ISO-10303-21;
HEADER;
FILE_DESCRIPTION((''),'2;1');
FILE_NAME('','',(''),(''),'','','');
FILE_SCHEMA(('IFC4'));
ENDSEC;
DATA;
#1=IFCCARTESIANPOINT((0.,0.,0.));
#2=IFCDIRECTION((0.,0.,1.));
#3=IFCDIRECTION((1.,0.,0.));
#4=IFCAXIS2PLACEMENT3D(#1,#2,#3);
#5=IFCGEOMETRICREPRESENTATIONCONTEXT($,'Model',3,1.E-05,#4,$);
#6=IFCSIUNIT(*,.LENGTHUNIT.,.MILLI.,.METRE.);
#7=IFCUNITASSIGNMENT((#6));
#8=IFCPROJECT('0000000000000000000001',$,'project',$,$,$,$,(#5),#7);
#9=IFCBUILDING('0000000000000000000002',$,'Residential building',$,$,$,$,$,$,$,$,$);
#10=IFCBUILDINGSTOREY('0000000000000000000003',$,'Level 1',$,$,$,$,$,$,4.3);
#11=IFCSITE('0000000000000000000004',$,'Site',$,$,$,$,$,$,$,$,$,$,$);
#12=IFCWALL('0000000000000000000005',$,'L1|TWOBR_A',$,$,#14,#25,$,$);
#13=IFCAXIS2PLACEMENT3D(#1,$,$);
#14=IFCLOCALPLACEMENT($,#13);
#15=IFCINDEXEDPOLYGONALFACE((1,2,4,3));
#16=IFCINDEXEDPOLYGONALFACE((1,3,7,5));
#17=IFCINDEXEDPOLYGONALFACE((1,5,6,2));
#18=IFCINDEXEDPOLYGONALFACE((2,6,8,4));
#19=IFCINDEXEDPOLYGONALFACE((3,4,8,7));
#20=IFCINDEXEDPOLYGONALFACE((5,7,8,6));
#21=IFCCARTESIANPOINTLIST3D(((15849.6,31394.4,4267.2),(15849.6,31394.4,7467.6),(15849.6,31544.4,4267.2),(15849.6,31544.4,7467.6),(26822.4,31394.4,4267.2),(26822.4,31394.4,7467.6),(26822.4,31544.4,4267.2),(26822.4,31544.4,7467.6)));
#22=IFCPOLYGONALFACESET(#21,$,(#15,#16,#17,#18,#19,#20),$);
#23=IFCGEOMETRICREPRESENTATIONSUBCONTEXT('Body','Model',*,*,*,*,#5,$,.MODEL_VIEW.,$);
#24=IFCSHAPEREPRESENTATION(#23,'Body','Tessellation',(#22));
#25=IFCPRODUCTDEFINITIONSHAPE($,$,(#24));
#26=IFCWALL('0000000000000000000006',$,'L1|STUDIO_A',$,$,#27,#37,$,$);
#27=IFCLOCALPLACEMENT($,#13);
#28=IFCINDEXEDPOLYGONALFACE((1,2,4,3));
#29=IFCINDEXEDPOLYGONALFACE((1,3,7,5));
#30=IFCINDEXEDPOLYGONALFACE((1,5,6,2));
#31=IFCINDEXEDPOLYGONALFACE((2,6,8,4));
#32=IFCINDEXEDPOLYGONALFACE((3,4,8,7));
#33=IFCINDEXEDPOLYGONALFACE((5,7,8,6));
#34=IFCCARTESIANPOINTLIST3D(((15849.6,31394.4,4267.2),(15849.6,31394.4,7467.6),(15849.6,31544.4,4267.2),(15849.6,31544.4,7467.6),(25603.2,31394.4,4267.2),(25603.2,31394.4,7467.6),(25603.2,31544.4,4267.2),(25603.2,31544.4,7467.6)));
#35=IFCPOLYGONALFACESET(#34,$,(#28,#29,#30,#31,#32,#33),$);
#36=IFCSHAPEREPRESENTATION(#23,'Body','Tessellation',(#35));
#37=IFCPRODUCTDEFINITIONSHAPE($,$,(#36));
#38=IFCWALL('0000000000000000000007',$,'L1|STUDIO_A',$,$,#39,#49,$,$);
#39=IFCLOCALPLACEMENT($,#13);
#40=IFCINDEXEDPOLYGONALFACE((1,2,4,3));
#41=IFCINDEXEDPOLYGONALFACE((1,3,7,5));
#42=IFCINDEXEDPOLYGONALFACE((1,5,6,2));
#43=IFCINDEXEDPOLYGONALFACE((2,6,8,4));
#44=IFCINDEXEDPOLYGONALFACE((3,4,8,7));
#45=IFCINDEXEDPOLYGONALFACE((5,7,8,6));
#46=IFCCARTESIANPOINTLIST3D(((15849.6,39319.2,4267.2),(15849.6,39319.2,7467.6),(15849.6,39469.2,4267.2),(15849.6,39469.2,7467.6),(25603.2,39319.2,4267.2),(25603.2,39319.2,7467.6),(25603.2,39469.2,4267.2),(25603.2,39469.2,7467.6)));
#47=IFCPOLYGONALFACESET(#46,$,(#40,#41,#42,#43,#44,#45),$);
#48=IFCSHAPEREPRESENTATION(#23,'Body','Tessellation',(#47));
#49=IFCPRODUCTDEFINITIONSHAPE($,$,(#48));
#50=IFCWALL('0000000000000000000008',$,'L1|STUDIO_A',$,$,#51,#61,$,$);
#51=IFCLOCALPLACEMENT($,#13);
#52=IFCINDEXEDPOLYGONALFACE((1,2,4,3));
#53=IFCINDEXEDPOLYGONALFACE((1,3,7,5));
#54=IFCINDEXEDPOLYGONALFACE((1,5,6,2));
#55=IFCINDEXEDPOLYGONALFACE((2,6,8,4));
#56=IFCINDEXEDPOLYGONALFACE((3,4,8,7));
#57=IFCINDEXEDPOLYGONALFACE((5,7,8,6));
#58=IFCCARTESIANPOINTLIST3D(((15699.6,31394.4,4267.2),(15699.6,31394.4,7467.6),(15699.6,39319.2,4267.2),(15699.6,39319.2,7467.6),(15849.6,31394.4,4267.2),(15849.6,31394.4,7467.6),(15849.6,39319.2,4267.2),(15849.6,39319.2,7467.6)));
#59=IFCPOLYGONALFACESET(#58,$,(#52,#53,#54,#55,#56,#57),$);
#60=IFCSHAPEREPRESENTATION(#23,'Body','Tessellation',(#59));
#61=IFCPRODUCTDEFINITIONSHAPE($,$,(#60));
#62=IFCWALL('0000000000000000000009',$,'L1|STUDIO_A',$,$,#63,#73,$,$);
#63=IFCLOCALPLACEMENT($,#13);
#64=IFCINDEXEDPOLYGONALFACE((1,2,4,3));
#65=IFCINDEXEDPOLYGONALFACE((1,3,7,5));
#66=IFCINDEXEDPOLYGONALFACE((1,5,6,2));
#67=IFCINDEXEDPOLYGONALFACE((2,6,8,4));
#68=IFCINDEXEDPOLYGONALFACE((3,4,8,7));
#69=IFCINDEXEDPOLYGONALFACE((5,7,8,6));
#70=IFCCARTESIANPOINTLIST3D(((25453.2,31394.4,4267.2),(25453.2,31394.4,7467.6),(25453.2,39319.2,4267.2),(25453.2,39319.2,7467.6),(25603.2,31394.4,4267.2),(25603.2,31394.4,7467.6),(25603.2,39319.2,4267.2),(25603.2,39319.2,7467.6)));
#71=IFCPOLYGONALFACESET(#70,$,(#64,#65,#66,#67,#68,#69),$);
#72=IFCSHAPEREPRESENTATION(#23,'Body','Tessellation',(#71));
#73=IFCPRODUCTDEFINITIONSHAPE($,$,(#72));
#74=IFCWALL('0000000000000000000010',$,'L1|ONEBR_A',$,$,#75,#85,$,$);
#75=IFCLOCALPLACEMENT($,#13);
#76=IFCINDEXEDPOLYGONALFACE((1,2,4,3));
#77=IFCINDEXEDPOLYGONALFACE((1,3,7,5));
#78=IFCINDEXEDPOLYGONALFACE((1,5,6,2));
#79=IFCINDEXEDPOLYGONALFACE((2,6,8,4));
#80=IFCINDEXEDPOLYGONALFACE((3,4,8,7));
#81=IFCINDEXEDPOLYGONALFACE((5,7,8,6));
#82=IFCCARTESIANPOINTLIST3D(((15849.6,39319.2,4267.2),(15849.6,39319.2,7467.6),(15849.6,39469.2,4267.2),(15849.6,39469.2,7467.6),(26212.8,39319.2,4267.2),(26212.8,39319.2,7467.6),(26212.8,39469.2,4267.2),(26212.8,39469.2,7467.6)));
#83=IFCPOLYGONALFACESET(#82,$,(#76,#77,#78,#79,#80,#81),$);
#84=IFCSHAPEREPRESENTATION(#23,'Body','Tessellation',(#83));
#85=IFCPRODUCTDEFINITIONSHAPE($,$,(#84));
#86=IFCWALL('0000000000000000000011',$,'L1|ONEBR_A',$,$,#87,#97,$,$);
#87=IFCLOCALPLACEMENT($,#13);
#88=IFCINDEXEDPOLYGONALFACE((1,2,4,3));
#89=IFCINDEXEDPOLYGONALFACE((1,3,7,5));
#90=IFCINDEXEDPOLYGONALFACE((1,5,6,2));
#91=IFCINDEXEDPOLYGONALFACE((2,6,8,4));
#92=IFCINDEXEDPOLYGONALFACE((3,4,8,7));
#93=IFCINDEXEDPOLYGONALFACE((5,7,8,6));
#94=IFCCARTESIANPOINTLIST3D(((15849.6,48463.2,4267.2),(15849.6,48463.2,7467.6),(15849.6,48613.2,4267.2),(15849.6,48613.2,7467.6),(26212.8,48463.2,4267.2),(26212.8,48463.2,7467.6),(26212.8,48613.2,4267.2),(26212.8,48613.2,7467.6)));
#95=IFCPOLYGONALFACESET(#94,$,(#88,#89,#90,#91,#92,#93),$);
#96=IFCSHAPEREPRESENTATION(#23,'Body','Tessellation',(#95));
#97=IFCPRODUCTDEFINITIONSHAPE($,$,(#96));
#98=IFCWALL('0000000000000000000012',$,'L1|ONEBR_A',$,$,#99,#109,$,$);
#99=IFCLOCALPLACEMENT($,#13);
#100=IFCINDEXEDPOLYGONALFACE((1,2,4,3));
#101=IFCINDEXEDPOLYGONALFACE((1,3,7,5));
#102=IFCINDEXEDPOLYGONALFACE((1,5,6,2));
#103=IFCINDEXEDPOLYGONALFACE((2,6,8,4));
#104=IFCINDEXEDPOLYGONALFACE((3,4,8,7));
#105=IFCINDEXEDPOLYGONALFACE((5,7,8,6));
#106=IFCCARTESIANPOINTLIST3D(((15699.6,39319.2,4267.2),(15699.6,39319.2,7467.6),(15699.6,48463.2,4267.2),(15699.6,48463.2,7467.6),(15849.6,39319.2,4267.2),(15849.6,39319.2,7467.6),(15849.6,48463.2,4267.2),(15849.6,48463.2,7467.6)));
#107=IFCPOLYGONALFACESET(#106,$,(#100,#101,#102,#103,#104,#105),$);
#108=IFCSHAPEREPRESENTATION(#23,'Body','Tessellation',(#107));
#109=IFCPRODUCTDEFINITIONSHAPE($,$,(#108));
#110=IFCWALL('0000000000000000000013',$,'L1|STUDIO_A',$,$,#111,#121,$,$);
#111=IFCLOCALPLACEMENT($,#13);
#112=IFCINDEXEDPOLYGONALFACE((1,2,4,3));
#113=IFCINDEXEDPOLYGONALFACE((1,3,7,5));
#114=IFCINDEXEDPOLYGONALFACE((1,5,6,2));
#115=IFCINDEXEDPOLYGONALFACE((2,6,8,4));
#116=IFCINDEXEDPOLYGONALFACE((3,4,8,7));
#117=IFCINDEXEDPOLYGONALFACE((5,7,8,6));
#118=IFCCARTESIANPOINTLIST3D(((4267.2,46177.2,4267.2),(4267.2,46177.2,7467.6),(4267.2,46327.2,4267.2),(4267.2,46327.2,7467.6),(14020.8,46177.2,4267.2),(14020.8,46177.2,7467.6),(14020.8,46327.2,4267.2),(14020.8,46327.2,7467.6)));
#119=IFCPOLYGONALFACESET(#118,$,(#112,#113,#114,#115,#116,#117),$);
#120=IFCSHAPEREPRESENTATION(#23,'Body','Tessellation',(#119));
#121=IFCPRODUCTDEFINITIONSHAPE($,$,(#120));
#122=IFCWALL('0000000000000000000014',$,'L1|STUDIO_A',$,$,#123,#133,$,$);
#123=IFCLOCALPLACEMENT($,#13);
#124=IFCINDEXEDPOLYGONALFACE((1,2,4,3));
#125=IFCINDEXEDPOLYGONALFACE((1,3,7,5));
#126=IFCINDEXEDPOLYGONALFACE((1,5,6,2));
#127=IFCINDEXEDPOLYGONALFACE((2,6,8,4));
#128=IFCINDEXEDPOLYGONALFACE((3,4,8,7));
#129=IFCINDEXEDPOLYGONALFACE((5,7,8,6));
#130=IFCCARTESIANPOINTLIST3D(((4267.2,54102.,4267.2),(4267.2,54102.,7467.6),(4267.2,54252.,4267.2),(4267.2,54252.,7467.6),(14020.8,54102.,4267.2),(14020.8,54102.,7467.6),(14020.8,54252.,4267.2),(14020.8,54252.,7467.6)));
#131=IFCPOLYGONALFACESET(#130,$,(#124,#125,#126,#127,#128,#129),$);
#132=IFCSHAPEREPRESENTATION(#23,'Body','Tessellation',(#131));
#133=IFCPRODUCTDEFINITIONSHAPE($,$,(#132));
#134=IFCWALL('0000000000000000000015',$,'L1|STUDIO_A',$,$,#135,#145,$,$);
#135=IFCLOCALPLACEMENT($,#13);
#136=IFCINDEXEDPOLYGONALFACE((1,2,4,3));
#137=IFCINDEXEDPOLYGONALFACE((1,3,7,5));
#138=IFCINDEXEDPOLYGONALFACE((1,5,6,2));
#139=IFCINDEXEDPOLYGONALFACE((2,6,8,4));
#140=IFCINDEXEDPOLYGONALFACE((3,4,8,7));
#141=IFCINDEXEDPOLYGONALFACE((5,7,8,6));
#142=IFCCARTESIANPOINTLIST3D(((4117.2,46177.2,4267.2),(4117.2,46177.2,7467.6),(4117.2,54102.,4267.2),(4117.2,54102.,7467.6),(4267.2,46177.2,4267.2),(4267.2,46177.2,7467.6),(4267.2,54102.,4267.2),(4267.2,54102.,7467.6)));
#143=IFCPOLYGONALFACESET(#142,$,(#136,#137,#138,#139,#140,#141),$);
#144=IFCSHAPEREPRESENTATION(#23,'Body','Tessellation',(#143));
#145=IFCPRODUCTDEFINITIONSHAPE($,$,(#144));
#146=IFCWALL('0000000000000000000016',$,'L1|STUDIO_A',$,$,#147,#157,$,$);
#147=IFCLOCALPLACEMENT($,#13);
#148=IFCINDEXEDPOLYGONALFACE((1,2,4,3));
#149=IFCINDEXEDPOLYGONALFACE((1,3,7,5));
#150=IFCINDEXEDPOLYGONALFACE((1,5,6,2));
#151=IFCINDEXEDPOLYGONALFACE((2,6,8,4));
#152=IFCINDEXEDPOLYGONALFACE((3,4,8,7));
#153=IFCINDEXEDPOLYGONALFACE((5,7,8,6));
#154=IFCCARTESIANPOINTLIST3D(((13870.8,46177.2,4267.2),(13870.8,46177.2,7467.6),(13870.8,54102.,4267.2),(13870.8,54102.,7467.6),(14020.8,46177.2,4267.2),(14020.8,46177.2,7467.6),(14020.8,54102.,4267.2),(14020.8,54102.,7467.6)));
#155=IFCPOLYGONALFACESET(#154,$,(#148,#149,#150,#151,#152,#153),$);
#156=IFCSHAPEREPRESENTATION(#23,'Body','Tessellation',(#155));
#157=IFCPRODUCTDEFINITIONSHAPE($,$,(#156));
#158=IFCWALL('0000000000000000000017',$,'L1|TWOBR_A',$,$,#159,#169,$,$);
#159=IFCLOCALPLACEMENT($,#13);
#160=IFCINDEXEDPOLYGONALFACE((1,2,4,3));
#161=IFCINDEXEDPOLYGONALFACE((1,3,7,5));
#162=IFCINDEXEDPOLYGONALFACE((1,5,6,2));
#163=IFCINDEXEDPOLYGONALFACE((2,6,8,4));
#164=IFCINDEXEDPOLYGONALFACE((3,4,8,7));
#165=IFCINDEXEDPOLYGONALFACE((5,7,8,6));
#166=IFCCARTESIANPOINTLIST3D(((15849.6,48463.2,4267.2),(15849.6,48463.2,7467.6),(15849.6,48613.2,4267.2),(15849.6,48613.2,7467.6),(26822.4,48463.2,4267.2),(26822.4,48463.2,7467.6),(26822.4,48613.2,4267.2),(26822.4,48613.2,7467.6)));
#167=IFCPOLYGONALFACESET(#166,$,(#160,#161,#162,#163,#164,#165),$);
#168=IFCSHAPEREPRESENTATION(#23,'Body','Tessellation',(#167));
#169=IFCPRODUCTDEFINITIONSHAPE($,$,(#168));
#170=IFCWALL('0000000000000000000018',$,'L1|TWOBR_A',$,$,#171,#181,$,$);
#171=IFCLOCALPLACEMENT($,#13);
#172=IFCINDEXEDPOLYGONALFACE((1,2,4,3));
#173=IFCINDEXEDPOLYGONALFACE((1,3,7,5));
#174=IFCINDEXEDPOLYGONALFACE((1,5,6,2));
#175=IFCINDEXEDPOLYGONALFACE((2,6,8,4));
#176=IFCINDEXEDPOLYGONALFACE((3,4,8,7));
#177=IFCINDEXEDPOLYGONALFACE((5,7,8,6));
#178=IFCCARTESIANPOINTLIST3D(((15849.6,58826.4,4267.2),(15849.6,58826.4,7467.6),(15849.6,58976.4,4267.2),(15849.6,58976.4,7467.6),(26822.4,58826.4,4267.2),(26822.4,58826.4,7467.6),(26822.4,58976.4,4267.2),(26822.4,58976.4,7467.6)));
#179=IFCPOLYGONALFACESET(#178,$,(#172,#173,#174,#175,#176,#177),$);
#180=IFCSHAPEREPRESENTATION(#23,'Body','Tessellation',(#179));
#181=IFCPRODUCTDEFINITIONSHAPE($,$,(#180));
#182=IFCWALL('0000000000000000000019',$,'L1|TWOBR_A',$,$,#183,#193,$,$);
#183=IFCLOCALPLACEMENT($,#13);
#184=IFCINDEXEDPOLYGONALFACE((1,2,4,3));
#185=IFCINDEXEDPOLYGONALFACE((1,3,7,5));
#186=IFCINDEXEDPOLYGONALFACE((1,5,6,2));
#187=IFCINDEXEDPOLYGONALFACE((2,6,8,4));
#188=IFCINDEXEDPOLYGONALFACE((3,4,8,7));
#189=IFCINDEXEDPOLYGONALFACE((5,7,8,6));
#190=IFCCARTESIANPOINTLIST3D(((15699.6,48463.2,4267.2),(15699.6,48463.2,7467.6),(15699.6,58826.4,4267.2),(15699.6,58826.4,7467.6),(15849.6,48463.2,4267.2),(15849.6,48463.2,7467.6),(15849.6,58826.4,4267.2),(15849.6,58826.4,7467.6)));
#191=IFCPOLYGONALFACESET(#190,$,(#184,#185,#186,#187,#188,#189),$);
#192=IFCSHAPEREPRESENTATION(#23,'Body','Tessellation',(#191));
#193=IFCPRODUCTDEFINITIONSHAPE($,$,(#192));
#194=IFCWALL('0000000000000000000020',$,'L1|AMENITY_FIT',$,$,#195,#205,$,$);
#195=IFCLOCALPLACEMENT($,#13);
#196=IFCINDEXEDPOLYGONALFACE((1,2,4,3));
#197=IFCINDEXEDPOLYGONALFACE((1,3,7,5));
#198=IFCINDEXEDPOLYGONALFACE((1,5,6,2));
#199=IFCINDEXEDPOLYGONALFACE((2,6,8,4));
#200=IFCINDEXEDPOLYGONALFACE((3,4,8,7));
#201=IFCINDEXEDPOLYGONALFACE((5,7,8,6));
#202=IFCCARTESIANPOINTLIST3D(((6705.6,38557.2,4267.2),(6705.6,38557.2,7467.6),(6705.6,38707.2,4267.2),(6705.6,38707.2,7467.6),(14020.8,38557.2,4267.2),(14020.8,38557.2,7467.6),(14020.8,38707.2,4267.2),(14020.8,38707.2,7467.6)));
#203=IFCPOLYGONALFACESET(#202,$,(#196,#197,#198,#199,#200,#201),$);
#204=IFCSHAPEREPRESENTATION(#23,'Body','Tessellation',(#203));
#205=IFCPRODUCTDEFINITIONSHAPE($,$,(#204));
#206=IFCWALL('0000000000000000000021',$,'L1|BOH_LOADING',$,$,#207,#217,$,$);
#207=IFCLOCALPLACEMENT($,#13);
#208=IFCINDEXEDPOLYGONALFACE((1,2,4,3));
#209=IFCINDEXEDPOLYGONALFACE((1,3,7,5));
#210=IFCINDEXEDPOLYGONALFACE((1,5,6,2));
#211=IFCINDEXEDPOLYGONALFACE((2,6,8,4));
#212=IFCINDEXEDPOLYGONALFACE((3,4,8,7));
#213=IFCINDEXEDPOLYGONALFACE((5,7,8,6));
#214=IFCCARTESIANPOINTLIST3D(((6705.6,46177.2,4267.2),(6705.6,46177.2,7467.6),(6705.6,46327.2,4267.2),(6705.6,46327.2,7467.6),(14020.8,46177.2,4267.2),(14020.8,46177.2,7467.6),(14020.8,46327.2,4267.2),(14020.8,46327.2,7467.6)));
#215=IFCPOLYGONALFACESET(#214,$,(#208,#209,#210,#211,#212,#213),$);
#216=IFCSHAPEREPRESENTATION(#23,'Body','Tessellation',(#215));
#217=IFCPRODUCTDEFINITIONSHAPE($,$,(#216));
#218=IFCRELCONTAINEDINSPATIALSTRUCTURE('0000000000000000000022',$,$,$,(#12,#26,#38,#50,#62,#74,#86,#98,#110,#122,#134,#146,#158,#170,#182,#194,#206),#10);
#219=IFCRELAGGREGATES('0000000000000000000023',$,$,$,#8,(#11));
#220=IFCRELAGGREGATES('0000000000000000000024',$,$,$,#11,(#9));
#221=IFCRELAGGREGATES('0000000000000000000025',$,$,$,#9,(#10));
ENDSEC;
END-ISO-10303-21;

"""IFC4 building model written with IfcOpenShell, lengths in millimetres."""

from ifc_helpers import new_model, si_unit, frame, origin_with_axes, place, context, subcontext, project, spatial, indexed_curve, outline, extrude, element, save


model = new_model("IFC4")

# Units and contexts
model_context = context("Model", 3, precision=1e-05, world=origin_with_axes())
body_context = subcontext(model_context, "Body", "Model", "MODEL_VIEW")
ifc_project = project(units=[si_unit("LENGTHUNIT", "METRE", prefix="MILLI")], contexts=[model_context])

# Site, building, storey
site = spatial("IfcSite", under=ifc_project, Name="Site")
building = spatial("IfcBuilding", under=site, Name="Residential building")
storey = spatial("IfcBuildingStorey", under=building, Name="Level 1", Elevation=4.3)

# Walls
wall_1_placement = place(None, frame((15849.6, 31394.4, 4267.2), z_axis=(0.0, 0.0, 1.0), x_axis=(1.0, 0.0, 0.0)))
element("IfcWall", 1, at=wall_1_placement, inside=storey, Name="L1|TWOBR_A", context=body_context, shape_type="SweptSolid", body=[
    extrude(outline(indexed_curve([(0.0, 0.0), (0.0, 150.0), (10972.8, 150.0), (10972.8, 0.0), (0.0, 0.0)], self_intersect=False)), origin_with_axes(), (0.0, 0.0, 1.0), 3200.4),
])
for number, where, z_axis, x_axis, name in (
    (2, (15849.6, 31394.4, 4267.2), (0.0, 0.0, 1.0), (1.0, 0.0, 0.0), "L1|STUDIO_A"),
    (3, (15849.6, 39319.2, 4267.2), (0.0, 0.0, 1.0), (1.0, 0.0, 0.0), "L1|STUDIO_A"),
):
    element("IfcWall", number, at=place(None, frame(where, z_axis=z_axis, x_axis=x_axis)), inside=storey, Name=name, context=body_context, shape_type="SweptSolid", body=[
        extrude(outline(indexed_curve([(0.0, 0.0), (0.0, 150.0), (9753.6, 150.0), (9753.6, 0.0), (0.0, 0.0)], self_intersect=False)), origin_with_axes(), (0.0, 0.0, 1.0), 3200.4),
    ])
for number, where, z_axis, x_axis, name in (
    (4, (15849.6, 31394.4, 4267.2), (0.0, 0.0, 1.0), (0.0, 1.0, 0.0), "L1|STUDIO_A"),
    (5, (25603.2, 31394.4, 4267.2), (0.0, 0.0, 1.0), (0.0, 1.0, 0.0), "L1|STUDIO_A"),
):
    element("IfcWall", number, at=place(None, frame(where, z_axis=z_axis, x_axis=x_axis)), inside=storey, Name=name, context=body_context, shape_type="SweptSolid", body=[
        extrude(outline(indexed_curve([(0.0, 0.0), (0.0, 150.0), (7924.8, 150.0), (7924.8, 0.0), (0.0, 0.0)], self_intersect=False)), origin_with_axes(), (0.0, 0.0, 1.0), 3200.4),
    ])
for number, where, z_axis, x_axis, name in (
    (6, (15849.6, 39319.2, 4267.2), (0.0, 0.0, 1.0), (1.0, 0.0, 0.0), "L1|ONEBR_A"),
    (7, (15849.6, 48463.2, 4267.2), (0.0, 0.0, 1.0), (1.0, 0.0, 0.0), "L1|ONEBR_A"),
):
    element("IfcWall", number, at=place(None, frame(where, z_axis=z_axis, x_axis=x_axis)), inside=storey, Name=name, context=body_context, shape_type="SweptSolid", body=[
        extrude(outline(indexed_curve([(0.0, 0.0), (0.0, 150.0), (10363.2, 150.0), (10363.2, 0.0), (0.0, 0.0)], self_intersect=False)), origin_with_axes(), (0.0, 0.0, 1.0), 3200.4),
    ])
wall_2_placement = place(None, frame((15849.6, 39319.2, 4267.2), z_axis=(0.0, 0.0, 1.0), x_axis=(0.0, 1.0, 0.0)))
element("IfcWall", 8, at=wall_2_placement, inside=storey, Name="L1|ONEBR_A", context=body_context, shape_type="SweptSolid", body=[
    extrude(outline(indexed_curve([(0.0, 0.0), (0.0, 150.0), (9144.0, 150.0), (9144.0, 0.0), (0.0, 0.0)], self_intersect=False)), origin_with_axes(), (0.0, 0.0, 1.0), 3200.4),
])
for number, where, z_axis, x_axis, name in (
    (9, (4267.2, 46177.2, 4267.2), (0.0, 0.0, 1.0), (1.0, 0.0, 0.0), "L1|STUDIO_A"),
    (10, (4267.2, 54102.0, 4267.2), (0.0, 0.0, 1.0), (1.0, 0.0, 0.0), "L1|STUDIO_A"),
):
    element("IfcWall", number, at=place(None, frame(where, z_axis=z_axis, x_axis=x_axis)), inside=storey, Name=name, context=body_context, shape_type="SweptSolid", body=[
        extrude(outline(indexed_curve([(0.0, 0.0), (0.0, 150.0), (9753.6, 150.0), (9753.6, 0.0), (0.0, 0.0)], self_intersect=False)), origin_with_axes(), (0.0, 0.0, 1.0), 3200.4),
    ])
for number, where, z_axis, x_axis, name in (
    (11, (4267.2, 46177.2, 4267.2), (0.0, 0.0, 1.0), (0.0, 1.0, 0.0), "L1|STUDIO_A"),
    (12, (14020.8, 46177.2, 4267.2), (0.0, 0.0, 1.0), (0.0, 1.0, 0.0), "L1|STUDIO_A"),
):
    element("IfcWall", number, at=place(None, frame(where, z_axis=z_axis, x_axis=x_axis)), inside=storey, Name=name, context=body_context, shape_type="SweptSolid", body=[
        extrude(outline(indexed_curve([(0.0, 0.0), (0.0, 150.0), (7924.8, 150.0), (7924.8, 0.0), (0.0, 0.0)], self_intersect=False)), origin_with_axes(), (0.0, 0.0, 1.0), 3200.4),
    ])
for number, where, z_axis, x_axis, name in (
    (13, (15849.6, 48463.2, 4267.2), (0.0, 0.0, 1.0), (1.0, 0.0, 0.0), "L1|TWOBR_A"),
    (14, (15849.6, 58826.4, 4267.2), (0.0, 0.0, 1.0), (1.0, 0.0, 0.0), "L1|TWOBR_A"),
):
    element("IfcWall", number, at=place(None, frame(where, z_axis=z_axis, x_axis=x_axis)), inside=storey, Name=name, context=body_context, shape_type="SweptSolid", body=[
        extrude(outline(indexed_curve([(0.0, 0.0), (0.0, 150.0), (10972.8, 150.0), (10972.8, 0.0), (0.0, 0.0)], self_intersect=False)), origin_with_axes(), (0.0, 0.0, 1.0), 3200.4),
    ])
wall_3_placement = place(None, frame((15849.6, 48463.2, 4267.2), z_axis=(0.0, 0.0, 1.0), x_axis=(0.0, 1.0, 0.0)))
element("IfcWall", 15, at=wall_3_placement, inside=storey, Name="L1|TWOBR_A", context=body_context, shape_type="SweptSolid", body=[
    extrude(outline(indexed_curve([(0.0, 0.0), (0.0, 150.0), (10363.2, 150.0), (10363.2, 0.0), (0.0, 0.0)], self_intersect=False)), origin_with_axes(), (0.0, 0.0, 1.0), 3200.4),
])
for number, where, z_axis, x_axis, name in (
    (16, (6705.6, 38557.2, 4267.2), (0.0, 0.0, 1.0), (1.0, 0.0, 0.0), "L1|AMENITY_FIT"),
    (17, (6705.6, 46177.2, 4267.2), (0.0, 0.0, 1.0), (1.0, 0.0, 0.0), "L1|BOH_LOADING"),
):
    element("IfcWall", number, at=place(None, frame(where, z_axis=z_axis, x_axis=x_axis)), inside=storey, Name=name, context=body_context, shape_type="SweptSolid", body=[
        extrude(outline(indexed_curve([(0.0, 0.0), (0.0, 150.0), (7315.2, 150.0), (7315.2, 0.0), (0.0, 0.0)], self_intersect=False)), origin_with_axes(), (0.0, 0.0, 1.0), 3200.4),
    ])

save(model, "model.ifc")
